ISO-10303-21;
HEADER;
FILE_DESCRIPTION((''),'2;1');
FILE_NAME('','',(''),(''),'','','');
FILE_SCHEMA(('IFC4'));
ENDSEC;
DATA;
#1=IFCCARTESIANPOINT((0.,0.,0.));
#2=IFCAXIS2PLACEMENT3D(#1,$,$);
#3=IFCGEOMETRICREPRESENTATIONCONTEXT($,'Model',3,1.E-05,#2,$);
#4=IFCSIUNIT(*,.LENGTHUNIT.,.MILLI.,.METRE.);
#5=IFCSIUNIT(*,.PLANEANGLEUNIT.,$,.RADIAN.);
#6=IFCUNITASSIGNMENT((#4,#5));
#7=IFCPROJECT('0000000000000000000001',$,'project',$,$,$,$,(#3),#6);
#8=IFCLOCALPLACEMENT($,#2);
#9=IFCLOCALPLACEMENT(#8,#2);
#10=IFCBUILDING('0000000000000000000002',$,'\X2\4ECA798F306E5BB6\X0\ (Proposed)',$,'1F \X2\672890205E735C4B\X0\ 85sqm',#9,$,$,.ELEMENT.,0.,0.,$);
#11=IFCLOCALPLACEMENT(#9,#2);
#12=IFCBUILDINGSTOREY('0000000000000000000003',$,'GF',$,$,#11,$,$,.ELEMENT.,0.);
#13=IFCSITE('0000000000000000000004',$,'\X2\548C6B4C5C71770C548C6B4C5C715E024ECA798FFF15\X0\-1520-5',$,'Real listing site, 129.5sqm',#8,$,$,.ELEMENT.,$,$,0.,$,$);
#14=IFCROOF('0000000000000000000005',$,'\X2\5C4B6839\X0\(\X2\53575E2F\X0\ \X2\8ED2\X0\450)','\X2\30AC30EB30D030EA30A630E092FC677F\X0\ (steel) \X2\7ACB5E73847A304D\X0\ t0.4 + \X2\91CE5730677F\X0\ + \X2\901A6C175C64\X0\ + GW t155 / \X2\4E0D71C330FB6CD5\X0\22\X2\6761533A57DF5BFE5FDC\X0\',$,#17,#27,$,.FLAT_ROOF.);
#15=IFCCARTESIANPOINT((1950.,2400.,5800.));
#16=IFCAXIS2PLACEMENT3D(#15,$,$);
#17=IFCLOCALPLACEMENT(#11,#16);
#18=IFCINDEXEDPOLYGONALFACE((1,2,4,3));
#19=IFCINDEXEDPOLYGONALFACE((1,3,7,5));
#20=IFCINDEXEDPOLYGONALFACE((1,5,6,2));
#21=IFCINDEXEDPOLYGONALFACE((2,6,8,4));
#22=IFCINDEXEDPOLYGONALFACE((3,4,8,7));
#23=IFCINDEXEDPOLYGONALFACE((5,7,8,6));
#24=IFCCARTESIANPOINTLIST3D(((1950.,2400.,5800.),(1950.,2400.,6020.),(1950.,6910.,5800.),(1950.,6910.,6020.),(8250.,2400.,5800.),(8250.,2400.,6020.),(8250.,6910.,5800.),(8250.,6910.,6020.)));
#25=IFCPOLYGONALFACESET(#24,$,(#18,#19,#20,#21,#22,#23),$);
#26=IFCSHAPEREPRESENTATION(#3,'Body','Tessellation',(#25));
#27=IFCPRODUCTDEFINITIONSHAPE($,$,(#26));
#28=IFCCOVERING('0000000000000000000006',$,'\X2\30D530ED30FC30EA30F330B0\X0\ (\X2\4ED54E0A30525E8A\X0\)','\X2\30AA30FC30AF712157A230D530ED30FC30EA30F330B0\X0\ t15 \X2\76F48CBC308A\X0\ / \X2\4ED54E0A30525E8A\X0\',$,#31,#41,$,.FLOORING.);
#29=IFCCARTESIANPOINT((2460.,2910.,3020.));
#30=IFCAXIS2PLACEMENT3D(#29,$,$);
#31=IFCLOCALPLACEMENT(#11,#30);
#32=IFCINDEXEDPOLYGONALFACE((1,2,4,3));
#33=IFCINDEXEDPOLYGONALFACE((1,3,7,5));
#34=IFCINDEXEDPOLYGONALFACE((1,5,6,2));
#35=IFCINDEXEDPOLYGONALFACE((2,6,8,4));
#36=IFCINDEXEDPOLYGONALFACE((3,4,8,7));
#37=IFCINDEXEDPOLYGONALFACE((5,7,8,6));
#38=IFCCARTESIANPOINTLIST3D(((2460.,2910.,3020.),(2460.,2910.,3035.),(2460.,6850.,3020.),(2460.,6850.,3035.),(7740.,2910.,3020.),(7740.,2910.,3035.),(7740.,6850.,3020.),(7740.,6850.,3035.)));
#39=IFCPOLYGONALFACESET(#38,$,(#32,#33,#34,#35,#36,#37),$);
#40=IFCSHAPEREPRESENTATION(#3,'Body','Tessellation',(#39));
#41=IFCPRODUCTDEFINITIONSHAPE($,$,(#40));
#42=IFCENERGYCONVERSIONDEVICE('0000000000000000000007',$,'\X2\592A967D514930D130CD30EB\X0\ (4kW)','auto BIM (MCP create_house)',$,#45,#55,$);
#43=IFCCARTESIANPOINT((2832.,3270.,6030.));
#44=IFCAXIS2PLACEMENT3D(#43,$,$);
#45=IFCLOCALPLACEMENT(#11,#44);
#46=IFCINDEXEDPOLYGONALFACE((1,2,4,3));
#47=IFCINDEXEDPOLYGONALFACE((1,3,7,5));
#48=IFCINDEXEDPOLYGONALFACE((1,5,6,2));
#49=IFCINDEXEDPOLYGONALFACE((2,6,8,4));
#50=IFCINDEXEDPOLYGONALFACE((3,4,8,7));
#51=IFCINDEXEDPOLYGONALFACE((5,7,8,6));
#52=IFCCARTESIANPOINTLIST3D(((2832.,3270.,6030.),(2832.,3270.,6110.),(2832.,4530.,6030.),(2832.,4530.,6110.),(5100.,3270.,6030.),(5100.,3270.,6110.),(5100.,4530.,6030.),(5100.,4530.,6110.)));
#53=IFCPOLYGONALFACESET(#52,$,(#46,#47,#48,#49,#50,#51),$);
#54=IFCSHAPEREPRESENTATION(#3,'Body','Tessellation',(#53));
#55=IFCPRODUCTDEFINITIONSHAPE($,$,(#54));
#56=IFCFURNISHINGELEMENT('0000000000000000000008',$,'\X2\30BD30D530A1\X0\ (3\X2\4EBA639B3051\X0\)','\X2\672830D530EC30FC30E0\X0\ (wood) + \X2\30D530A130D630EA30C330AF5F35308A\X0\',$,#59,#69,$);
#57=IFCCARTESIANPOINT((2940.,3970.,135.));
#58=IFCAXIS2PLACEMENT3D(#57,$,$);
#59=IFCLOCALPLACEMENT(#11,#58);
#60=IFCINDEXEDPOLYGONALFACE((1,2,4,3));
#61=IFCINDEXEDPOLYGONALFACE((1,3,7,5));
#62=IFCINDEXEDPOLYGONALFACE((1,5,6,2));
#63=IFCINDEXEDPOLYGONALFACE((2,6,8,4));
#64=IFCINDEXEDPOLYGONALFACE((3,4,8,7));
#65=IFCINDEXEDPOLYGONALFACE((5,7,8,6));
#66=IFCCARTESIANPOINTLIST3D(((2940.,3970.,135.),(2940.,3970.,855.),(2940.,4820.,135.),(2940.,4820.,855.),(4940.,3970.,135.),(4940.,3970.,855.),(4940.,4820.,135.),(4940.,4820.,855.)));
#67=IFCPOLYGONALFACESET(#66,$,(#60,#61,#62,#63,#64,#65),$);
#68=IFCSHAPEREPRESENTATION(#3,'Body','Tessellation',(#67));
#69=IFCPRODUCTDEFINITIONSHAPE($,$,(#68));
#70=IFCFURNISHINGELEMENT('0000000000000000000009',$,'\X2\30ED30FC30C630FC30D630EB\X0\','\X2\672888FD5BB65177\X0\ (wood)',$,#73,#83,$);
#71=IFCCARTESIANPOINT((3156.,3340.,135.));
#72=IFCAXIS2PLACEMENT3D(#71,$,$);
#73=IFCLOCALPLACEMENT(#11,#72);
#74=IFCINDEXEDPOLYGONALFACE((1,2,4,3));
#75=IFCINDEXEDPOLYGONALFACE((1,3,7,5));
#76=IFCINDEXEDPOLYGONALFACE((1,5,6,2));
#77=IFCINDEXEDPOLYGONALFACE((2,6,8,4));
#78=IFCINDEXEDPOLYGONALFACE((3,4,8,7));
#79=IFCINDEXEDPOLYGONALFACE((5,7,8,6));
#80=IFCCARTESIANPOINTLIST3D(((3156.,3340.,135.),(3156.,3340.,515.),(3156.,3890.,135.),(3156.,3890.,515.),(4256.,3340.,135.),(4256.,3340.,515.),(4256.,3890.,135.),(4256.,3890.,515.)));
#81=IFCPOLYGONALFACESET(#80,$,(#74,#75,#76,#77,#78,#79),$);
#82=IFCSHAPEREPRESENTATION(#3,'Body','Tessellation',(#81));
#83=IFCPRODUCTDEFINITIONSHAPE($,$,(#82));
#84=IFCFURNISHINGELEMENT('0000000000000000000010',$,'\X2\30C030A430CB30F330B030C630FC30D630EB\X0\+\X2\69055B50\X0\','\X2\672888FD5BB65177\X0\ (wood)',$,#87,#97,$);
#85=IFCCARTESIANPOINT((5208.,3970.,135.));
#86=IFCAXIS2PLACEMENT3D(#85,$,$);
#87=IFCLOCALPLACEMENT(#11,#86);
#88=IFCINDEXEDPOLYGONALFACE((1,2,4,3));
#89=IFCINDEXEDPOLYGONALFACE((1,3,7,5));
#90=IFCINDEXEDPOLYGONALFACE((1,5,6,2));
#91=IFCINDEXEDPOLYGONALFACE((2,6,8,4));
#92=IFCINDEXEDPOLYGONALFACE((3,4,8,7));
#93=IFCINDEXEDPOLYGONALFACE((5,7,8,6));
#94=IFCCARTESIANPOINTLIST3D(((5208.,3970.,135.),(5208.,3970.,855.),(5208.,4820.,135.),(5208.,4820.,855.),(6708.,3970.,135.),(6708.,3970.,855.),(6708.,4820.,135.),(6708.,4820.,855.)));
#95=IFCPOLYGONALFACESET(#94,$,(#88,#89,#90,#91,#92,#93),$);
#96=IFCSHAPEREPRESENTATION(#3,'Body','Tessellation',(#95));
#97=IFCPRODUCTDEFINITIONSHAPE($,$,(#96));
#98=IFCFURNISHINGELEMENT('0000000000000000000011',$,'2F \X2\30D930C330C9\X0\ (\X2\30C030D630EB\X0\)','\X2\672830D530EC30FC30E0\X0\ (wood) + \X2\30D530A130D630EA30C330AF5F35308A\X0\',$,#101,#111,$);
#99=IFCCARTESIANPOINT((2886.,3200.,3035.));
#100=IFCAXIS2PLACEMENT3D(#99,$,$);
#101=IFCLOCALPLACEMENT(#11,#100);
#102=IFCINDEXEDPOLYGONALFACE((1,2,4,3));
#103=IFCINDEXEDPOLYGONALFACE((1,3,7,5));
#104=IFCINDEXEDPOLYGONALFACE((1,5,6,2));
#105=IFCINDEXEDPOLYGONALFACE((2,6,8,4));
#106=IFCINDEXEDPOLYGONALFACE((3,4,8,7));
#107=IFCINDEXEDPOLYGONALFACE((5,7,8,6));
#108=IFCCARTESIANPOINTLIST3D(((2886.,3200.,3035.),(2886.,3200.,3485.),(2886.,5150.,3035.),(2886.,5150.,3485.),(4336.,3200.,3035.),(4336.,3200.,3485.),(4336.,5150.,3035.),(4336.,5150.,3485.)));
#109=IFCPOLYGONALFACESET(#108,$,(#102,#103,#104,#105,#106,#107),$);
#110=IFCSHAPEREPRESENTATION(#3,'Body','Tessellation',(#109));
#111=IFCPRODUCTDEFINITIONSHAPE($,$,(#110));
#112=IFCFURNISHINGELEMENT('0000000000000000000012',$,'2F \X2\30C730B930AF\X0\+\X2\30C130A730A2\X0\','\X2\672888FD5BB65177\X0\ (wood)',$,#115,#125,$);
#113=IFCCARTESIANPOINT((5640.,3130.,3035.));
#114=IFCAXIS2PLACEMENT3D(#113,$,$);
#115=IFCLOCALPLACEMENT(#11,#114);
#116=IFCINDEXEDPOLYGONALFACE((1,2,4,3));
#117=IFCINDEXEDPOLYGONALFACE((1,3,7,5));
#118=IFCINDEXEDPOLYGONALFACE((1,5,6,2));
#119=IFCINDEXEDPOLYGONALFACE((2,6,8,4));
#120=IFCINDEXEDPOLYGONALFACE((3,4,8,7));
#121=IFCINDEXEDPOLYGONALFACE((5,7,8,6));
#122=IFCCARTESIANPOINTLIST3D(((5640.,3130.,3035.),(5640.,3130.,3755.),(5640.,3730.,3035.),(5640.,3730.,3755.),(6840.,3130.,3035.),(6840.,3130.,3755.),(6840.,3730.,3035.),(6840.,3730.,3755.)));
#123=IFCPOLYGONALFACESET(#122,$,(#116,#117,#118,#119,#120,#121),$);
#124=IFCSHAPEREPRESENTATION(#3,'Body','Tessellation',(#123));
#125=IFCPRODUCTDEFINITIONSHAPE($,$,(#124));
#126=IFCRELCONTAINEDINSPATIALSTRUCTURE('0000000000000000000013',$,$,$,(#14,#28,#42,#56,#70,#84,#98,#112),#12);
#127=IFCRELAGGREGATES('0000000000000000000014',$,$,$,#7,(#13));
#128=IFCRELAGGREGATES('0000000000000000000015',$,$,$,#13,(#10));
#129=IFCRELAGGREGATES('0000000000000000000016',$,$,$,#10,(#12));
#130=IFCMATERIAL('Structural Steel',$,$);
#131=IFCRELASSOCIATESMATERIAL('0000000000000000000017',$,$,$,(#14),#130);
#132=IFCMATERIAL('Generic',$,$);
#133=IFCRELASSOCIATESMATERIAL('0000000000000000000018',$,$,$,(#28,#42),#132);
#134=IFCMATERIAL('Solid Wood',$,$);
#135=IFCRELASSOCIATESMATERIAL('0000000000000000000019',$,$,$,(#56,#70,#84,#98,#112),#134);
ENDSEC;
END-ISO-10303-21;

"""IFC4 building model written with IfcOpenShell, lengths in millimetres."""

from ifc_helpers import new_model, si_unit, frame, frame_2d, origin, place, context, project, spatial, rectangle, extrude, material, element, save


model = new_model("IFC4")

# Units and contexts
model_context = context("Model", 3, precision=1e-05, world=origin())
ifc_project = project(units=[si_unit("LENGTHUNIT", "METRE", prefix="MILLI"), si_unit("PLANEANGLEUNIT", "RADIAN")], contexts=[model_context])

# Site, building, storey
site_placement = place(None, origin())
site = spatial("IfcSite", under=ifc_project, at=site_placement, Name="和歌山県和歌山市今福５-1520-5", ObjectType="Real listing site, 129.5sqm", CompositionType="ELEMENT", RefElevation=0.0)
building_placement = place(site_placement, origin())
building = spatial("IfcBuilding", under=site, at=building_placement, Name="今福の家 (Proposed)", ObjectType="1F 木造平屋 85sqm", CompositionType="ELEMENT", ElevationOfRefHeight=0.0, ElevationOfTerrain=0.0)
storey_placement = place(building_placement, origin())
storey = spatial("IfcBuildingStorey", under=building, at=storey_placement, Name="GF", CompositionType="ELEMENT", Elevation=0.0)

# Shared definitions
ifc_material_1 = material(Name="Solid Wood")

# Shared definitions
ifc_material_2 = material(Name="Generic")

# Roof
ifc_material_3 = material(Name="Structural Steel")
for number, where, name in (
    (1, (1950.0, 2400.0, 5800.0), "屋根(南帯 軒450)"),
):
    element("IfcRoof", number, at=place(storey_placement, frame(where)), inside=storey, material=ifc_material_3, Name=name, Description="ガルバリウム鋼板 (steel) 立平葺き t0.4 + 野地板 + 通気層 + GW t155 / 不燃・法22条区域対応", PredefinedType="FLAT_ROOF", context=model_context, shape_type="SweptSolid", body=[
        extrude(rectangle(XDim=6300.0, YDim=4510.0, at=frame_2d((3150.0, 2255.0))), frame((1950.0, 2400.0, 5800.0)), (0.0, 0.0, 1.0), 220.0),
    ])

# Covering
covering_placement = place(storey_placement, frame((2460.0, 2910.0, 3020.0)))
element("IfcCovering", 2, at=covering_placement, inside=storey, material=ifc_material_2, Name="フローリング (仕上げ床)", Description="オーク無垢フローリング t15 直貼り / 仕上げ床", PredefinedType="FLOORING", context=model_context, shape_type="SweptSolid", body=[
    extrude(rectangle(XDim=5280.0, YDim=3940.0, at=frame_2d((2640.0, 1970.0))), frame((2460.0, 2910.0, 3020.0)), (0.0, 0.0, 1.0), 15.0),
])

# Energy conversion device
energy_conversion_device_placement = place(storey_placement, frame((2832.0, 3270.0, 6030.0)))
element("IfcEnergyConversionDevice", 3, at=energy_conversion_device_placement, inside=storey, material=ifc_material_2, Name="太陽光パネル (4kW)", Description="auto BIM (MCP create_house)", context=model_context, shape_type="SweptSolid", body=[
    extrude(rectangle(XDim=2268.0, YDim=1260.0, at=frame_2d((1134.0, 630.0))), frame((2832.0, 3270.0, 6030.0)), (0.0, 0.0, 1.0), 80.0),
])

# Furnishing elements
furnishing_1_placement = place(storey_placement, frame((2940.0, 3970.0, 135.0)))
element("IfcFurnishingElement", 4, at=furnishing_1_placement, inside=storey, material=ifc_material_1, Name="ソファ (3人掛け)", Description="木フレーム (wood) + ファブリック張り", context=model_context, shape_type="SweptSolid", body=[
    extrude(rectangle(XDim=2000.0, YDim=850.0, at=frame_2d((1000.0, 425.0))), frame((2940.0, 3970.0, 135.0)), (0.0, 0.0, 1.0), 720.0),
])
furnishing_2_placement = place(storey_placement, frame((3156.0, 3340.0, 135.0)))
element("IfcFurnishingElement", 5, at=furnishing_2_placement, inside=storey, material=ifc_material_1, Name="ローテーブル", Description="木製家具 (wood)", context=model_context, shape_type="SweptSolid", body=[
    extrude(rectangle(XDim=1100.0, YDim=550.0, at=frame_2d((550.0, 275.0))), frame((3156.0, 3340.0, 135.0)), (0.0, 0.0, 1.0), 380.0),
])
furnishing_3_placement = place(storey_placement, frame((5208.0, 3970.0, 135.0)))
element("IfcFurnishingElement", 6, at=furnishing_3_placement, inside=storey, material=ifc_material_1, Name="ダイニングテーブル+椅子", Description="木製家具 (wood)", context=model_context, shape_type="SweptSolid", body=[
    extrude(rectangle(XDim=1500.0, YDim=850.0, at=frame_2d((750.0, 425.0))), frame((5208.0, 3970.0, 135.0)), (0.0, 0.0, 1.0), 720.0),
])
furnishing_4_placement = place(storey_placement, frame((2886.0, 3200.0, 3035.0)))
element("IfcFurnishingElement", 7, at=furnishing_4_placement, inside=storey, material=ifc_material_1, Name="2F ベッド (ダブル)", Description="木フレーム (wood) + ファブリック張り", context=model_context, shape_type="SweptSolid", body=[
    extrude(rectangle(XDim=1450.0, YDim=1950.0, at=frame_2d((725.0, 975.0))), frame((2886.0, 3200.0, 3035.0)), (0.0, 0.0, 1.0), 450.0),
])
furnishing_5_placement = place(storey_placement, frame((5640.0, 3130.0, 3035.0)))
element("IfcFurnishingElement", 8, at=furnishing_5_placement, inside=storey, material=ifc_material_1, Name="2F デスク+チェア", Description="木製家具 (wood)", context=model_context, shape_type="SweptSolid", body=[
    extrude(rectangle(XDim=1200.0, YDim=600.0, at=frame_2d((600.0, 300.0))), frame((5640.0, 3130.0, 3035.0)), (0.0, 0.0, 1.0), 720.0),
])

save(model, "model.ifc")
